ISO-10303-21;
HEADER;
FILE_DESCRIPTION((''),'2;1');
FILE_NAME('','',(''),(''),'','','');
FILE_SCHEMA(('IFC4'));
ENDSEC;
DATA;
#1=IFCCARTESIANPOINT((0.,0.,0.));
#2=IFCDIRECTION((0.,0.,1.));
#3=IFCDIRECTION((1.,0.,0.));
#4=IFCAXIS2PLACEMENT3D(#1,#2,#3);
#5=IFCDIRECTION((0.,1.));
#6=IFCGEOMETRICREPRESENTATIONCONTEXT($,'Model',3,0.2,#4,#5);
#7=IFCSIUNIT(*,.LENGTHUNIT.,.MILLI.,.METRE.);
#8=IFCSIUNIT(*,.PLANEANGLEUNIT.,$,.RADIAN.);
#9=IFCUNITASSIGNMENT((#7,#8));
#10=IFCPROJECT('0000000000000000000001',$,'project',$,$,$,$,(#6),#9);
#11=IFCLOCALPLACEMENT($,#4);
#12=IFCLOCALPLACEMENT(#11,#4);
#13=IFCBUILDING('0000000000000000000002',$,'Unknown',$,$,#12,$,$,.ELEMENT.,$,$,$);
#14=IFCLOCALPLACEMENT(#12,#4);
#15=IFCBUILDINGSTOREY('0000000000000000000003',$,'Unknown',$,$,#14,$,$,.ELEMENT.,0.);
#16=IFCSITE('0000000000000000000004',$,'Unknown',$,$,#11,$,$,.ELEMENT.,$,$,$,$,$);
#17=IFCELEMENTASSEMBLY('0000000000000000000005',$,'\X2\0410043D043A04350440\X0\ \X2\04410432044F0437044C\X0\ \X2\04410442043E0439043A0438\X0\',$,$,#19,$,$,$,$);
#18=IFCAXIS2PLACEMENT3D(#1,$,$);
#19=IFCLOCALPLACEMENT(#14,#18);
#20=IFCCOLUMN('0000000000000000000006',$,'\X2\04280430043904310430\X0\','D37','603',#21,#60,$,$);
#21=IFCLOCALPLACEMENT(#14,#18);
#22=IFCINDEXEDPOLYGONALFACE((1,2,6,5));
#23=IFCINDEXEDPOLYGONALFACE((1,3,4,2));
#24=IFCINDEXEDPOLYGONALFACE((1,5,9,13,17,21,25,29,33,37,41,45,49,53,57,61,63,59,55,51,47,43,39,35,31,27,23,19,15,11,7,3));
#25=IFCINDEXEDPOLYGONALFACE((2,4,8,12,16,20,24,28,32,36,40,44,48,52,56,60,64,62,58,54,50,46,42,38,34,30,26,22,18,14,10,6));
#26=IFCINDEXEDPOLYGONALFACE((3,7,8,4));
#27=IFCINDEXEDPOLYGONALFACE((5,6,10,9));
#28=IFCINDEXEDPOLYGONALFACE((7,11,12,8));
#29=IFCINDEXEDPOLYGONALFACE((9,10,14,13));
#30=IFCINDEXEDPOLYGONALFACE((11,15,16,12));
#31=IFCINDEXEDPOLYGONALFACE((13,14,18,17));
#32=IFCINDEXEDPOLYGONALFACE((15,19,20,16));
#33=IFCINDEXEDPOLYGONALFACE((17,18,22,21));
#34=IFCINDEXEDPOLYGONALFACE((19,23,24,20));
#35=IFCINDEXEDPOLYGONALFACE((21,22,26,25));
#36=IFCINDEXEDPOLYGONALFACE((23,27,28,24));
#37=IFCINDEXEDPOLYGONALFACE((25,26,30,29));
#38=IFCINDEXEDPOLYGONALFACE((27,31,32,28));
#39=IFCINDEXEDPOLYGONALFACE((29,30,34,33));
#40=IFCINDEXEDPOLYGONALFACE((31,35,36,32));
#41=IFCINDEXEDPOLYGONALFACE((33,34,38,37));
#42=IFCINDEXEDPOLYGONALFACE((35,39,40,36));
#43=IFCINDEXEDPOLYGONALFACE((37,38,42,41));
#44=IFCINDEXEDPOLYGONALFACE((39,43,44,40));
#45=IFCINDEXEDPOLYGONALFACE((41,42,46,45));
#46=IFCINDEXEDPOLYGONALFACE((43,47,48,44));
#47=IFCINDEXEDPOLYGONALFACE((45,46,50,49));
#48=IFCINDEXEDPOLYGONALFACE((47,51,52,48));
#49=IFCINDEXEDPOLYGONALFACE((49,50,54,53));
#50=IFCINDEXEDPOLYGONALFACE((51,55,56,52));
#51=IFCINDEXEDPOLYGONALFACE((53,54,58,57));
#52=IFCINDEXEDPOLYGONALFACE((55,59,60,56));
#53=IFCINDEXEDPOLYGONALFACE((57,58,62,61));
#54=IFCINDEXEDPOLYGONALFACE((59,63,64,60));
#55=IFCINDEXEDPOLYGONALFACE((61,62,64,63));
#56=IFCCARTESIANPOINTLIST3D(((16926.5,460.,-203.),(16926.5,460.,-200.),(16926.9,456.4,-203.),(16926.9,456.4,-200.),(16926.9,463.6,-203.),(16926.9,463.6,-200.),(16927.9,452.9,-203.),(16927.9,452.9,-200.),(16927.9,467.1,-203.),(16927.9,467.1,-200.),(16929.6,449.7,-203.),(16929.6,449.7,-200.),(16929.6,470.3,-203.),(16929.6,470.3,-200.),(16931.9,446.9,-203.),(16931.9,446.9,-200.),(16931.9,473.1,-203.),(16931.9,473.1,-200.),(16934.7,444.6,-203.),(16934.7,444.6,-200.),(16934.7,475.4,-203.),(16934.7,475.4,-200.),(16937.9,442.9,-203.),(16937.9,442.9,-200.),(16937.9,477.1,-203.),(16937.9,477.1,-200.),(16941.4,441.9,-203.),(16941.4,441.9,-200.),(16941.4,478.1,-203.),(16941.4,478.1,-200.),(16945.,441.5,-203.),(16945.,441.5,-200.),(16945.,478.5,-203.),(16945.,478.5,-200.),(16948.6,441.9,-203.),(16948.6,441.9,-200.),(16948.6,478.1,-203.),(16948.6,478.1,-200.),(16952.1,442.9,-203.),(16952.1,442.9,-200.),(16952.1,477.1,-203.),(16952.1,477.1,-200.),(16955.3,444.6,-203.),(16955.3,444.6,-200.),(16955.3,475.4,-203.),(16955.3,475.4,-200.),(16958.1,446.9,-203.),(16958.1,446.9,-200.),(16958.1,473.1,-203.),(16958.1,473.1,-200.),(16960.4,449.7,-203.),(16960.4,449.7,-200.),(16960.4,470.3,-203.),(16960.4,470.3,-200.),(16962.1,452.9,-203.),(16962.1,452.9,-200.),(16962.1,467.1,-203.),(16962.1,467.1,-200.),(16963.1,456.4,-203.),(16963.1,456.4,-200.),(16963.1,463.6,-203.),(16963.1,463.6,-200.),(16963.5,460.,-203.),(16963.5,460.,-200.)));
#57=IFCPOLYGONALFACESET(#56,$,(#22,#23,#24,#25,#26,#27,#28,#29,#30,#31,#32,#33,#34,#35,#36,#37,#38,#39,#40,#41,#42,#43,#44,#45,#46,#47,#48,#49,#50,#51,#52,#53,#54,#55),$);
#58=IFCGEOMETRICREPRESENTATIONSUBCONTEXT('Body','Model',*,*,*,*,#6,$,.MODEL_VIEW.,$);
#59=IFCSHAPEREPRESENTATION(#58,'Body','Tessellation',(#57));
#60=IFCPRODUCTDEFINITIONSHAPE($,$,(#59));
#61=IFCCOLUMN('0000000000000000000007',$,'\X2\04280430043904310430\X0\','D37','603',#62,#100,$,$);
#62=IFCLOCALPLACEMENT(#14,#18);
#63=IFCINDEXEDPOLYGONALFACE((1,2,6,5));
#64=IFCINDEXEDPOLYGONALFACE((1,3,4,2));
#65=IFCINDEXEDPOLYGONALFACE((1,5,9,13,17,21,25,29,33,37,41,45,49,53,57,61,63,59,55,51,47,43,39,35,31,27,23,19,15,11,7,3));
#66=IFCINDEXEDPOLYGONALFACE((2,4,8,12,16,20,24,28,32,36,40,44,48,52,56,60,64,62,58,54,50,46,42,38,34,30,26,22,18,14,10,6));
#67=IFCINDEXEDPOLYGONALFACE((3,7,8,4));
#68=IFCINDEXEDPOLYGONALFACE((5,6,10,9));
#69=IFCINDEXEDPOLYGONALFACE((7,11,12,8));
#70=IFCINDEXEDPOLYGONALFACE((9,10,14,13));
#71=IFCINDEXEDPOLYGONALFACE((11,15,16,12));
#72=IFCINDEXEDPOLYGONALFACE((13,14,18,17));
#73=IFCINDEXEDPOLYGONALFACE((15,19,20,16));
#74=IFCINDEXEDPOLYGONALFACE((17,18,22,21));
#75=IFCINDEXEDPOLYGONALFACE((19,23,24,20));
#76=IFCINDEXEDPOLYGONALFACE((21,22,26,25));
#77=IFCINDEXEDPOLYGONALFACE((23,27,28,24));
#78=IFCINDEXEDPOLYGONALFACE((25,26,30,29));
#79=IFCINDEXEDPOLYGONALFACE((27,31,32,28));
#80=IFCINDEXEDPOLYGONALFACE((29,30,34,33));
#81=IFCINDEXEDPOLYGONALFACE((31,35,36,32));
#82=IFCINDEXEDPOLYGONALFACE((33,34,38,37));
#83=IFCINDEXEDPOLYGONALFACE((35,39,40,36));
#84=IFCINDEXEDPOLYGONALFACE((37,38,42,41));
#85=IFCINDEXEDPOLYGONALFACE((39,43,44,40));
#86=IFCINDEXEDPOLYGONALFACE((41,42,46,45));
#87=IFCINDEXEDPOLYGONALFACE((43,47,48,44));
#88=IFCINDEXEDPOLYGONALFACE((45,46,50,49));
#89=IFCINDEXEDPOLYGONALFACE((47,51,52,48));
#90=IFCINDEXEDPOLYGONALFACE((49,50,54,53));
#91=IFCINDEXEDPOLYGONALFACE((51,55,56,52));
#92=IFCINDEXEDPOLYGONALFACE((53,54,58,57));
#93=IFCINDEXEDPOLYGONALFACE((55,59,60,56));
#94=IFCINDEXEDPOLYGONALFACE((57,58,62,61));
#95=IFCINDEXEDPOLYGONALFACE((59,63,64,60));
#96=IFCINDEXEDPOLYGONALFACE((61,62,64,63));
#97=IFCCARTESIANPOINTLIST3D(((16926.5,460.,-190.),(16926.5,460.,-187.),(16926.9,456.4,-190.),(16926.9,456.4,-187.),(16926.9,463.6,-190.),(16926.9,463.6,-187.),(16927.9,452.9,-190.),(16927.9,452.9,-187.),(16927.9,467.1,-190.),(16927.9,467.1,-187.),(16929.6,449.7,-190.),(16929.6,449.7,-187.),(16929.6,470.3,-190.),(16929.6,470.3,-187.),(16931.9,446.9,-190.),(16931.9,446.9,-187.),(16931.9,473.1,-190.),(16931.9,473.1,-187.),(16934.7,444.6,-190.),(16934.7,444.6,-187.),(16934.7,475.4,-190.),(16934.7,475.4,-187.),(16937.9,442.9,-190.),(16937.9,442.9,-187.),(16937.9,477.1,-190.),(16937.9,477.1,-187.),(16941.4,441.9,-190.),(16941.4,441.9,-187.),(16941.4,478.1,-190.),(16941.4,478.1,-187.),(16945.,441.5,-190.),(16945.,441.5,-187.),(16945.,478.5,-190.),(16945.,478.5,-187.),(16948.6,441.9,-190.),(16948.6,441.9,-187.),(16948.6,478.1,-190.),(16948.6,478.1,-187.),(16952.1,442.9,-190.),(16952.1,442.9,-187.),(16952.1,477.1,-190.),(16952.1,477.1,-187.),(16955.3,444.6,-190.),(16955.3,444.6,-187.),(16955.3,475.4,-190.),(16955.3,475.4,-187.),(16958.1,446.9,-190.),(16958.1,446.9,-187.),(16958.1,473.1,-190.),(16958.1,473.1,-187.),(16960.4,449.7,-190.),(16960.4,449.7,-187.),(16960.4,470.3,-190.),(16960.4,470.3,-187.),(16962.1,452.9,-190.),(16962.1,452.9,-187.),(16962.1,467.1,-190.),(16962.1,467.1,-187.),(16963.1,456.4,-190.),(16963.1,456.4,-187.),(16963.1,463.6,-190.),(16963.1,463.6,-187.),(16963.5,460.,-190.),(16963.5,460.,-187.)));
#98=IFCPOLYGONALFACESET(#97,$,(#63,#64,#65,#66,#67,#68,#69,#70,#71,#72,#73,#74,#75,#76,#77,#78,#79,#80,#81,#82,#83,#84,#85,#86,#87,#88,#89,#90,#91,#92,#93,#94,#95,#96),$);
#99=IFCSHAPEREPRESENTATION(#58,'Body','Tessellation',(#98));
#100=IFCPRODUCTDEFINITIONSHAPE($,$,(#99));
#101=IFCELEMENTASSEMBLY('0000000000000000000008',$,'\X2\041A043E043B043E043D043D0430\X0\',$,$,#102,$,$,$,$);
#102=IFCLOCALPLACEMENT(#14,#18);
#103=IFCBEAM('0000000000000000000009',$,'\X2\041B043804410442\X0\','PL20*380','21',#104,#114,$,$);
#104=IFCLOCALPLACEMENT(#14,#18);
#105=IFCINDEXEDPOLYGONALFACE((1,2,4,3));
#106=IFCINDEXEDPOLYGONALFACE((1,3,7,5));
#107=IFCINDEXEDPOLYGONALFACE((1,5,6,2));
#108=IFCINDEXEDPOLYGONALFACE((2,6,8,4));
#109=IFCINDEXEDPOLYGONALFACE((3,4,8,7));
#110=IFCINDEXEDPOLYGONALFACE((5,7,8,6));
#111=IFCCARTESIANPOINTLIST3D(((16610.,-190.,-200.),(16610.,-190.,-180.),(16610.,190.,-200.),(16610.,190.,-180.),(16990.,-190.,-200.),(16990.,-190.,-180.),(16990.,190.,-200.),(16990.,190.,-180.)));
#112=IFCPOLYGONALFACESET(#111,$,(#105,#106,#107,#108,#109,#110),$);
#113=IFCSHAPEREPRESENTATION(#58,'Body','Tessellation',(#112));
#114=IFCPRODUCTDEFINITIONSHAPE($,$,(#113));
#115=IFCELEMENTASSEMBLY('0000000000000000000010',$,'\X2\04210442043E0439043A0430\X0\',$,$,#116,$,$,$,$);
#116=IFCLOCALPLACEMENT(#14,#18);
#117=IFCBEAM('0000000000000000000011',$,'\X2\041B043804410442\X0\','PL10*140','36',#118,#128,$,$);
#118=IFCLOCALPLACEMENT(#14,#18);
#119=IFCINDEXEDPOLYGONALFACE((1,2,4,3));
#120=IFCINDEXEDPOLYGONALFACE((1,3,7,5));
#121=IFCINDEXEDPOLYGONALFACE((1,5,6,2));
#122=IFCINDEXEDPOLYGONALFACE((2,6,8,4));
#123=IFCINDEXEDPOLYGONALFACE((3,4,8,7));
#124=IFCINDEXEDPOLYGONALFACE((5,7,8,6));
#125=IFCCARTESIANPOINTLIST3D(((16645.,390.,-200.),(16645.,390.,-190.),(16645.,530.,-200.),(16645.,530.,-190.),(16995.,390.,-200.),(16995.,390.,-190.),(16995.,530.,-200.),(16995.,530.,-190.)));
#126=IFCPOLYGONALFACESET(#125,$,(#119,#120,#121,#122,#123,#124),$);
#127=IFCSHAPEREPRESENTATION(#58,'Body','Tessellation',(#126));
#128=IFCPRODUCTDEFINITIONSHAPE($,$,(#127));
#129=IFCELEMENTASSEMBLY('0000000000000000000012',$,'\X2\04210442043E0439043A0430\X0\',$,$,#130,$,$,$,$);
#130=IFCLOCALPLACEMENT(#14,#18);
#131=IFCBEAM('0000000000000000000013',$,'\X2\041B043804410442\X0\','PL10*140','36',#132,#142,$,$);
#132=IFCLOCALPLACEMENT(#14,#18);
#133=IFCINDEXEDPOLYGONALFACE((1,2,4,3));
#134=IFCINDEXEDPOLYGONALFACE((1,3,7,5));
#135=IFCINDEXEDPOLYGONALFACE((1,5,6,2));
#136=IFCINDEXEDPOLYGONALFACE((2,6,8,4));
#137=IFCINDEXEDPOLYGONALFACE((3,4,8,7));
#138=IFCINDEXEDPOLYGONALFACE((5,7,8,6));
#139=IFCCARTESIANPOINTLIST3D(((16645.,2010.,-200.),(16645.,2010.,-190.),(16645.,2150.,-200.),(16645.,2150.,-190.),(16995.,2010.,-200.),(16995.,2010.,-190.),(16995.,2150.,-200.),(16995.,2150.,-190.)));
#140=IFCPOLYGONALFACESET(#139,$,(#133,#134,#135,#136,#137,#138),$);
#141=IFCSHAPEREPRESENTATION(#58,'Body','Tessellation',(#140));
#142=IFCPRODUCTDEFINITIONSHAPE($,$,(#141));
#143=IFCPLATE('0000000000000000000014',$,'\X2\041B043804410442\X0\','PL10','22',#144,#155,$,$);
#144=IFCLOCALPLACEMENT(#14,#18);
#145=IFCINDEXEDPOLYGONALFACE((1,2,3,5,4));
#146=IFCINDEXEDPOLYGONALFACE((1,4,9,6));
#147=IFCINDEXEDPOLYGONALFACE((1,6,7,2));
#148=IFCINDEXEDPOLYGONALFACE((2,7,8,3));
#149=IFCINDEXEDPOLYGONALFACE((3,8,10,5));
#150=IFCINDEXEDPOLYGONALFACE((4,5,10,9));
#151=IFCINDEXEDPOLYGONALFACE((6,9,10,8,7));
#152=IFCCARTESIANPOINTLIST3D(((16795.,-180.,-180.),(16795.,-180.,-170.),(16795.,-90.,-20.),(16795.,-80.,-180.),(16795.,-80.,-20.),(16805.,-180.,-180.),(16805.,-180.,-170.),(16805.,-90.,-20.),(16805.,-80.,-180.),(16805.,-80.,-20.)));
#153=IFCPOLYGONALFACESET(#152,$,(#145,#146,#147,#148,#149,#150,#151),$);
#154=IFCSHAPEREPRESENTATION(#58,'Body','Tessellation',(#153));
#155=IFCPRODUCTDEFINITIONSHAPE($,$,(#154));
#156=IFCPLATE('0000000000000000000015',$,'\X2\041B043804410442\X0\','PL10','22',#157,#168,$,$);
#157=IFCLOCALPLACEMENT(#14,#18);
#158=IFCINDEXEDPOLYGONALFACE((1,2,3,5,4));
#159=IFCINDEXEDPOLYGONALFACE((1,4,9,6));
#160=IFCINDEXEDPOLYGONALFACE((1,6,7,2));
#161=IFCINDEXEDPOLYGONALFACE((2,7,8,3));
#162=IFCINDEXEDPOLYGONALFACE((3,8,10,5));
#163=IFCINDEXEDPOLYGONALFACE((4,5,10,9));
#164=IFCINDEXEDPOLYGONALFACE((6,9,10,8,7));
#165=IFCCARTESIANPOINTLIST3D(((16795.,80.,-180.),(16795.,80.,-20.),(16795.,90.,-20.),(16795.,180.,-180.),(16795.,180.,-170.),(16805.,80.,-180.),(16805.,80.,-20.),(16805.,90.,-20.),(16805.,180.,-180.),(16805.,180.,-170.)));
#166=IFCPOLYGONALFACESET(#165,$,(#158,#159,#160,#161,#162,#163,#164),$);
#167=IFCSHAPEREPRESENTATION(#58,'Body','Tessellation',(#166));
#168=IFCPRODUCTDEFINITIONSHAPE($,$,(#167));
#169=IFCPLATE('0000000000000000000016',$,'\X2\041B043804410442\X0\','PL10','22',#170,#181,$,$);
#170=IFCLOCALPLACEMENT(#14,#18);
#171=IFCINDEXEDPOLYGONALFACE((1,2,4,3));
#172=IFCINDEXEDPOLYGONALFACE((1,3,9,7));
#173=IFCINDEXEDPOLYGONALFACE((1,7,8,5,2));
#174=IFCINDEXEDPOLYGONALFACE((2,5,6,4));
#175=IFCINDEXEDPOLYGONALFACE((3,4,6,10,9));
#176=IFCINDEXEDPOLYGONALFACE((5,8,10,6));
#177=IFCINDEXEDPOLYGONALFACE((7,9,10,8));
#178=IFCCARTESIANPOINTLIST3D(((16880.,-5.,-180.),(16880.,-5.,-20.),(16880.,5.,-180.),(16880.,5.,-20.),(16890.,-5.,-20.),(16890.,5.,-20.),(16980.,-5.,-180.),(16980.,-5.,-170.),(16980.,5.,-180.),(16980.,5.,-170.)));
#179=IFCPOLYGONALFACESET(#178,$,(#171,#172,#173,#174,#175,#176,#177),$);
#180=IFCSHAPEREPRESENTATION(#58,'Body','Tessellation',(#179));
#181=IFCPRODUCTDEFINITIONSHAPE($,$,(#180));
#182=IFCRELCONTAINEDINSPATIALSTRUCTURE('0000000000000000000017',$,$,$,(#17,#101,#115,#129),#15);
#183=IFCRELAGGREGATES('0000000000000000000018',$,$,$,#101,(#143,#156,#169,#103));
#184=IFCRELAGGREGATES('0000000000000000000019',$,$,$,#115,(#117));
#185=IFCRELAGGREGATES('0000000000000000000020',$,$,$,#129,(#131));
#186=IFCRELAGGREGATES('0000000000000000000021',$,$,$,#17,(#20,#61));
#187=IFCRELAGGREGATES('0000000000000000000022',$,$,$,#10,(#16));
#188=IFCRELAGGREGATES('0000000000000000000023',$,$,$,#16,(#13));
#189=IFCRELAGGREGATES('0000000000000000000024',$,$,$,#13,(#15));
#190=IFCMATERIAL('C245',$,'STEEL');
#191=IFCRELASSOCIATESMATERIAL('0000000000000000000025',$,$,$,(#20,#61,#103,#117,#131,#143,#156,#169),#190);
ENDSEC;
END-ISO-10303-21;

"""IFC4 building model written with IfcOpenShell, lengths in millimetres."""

from ifc_helpers import new_model, si_unit, direction, frame, origin_with_axes, place, context, subcontext, project, spatial, line, indexed_curve, outline, extrude, material, element, aggregate, save


model = new_model("IFC4")

# Units and contexts
model_context = context("Model", 3, precision=0.2, world=origin_with_axes(), true_north=direction((0.0, 1.0)))
body_context = subcontext(model_context, "Body", "Model", "MODEL_VIEW")
ifc_project = project(units=[si_unit("LENGTHUNIT", "METRE", prefix="MILLI"), si_unit("PLANEANGLEUNIT", "RADIAN")], contexts=[model_context])

# Site, building, storey
site_placement = place(None, origin_with_axes())
site = spatial("IfcSite", under=ifc_project, at=site_placement, Name="Unknown", CompositionType="ELEMENT")
building_placement = place(site_placement, origin_with_axes())
building = spatial("IfcBuilding", under=site, at=building_placement, Name="Unknown", CompositionType="ELEMENT")
storey_placement = place(building_placement, origin_with_axes())
storey = spatial("IfcBuildingStorey", under=building, at=storey_placement, Name="Unknown", CompositionType="ELEMENT", Elevation=0.0)

# Element assembly, columns
ifc_material_1 = material(Name="C245", Category="STEEL")
assembly_1_placement = place(storey_placement, frame((16945.0, 460.0, -160.0), z_axis=(0.0, -1.0, 0.0), x_axis=(0.0, 0.0, -1.0)))
assembly_1 = element("IfcElementAssembly", 1, at=assembly_1_placement, inside=storey, Name="Анкер связь стойки")
column_1_placement = place(assembly_1_placement, frame((40.0, 0.0, 0.0), z_axis=(0.0, -1.0, 0.0), x_axis=(1.0, 0.0, 0.0)))
column_1 = element("IfcColumn", 2, at=column_1_placement, material=ifc_material_1, Name="Шайба", Description="D37", ObjectType="603", context=body_context, shape_type="SolidModel", body=[
    extrude(outline(indexed_curve([(18.5, 0.0), (18.1, 3.6), (17.1, 7.1), (15.4, 10.3), (13.1, 13.1), (10.3, 15.4), (7.1, 17.1), (3.6, 18.1), (0.0, 18.5), (-3.6, 18.1), (-7.1, 17.1), (-10.3, 15.4), (-13.1, 13.1), (-15.4, 10.3), (-17.1, 7.1), (-18.1, 3.6), (-18.5, 0.0), (-18.1, -3.6), (-17.1, -7.1), (-15.4, -10.3), (-13.1, -13.1), (-10.3, -15.4), (-7.1, -17.1), (-3.6, -18.1), (0.0, -18.5), (3.6, -18.1), (7.1, -17.1), (10.3, -15.4), (13.1, -13.1), (15.4, -10.3), (17.1, -7.1), (18.1, -3.6)], segments=[line(1, 2, 3, 4, 5, 6, 7, 8, 9, 10, 11, 12, 13, 14, 15, 16, 17, 18, 19, 20, 21, 22, 23, 24, 25, 26, 27, 28, 29, 30, 31, 32, 1)])), frame((0.0, 0.0, 0.0), z_axis=(-1.0, 0.0, 0.0), x_axis=(0.0, 0.0, 1.0)), (0.0, 0.0, -1.0), 3.0),
])
column_2_placement = place(assembly_1_placement, frame((27.0, 0.0, 0.0), z_axis=(0.0, 0.0, 1.0), x_axis=(1.0, 0.0, 0.0)))
column_2 = element("IfcColumn", 3, at=column_2_placement, material=ifc_material_1, Name="Шайба", Description="D37", ObjectType="603", context=body_context, shape_type="SolidModel", body=[
    extrude(outline(indexed_curve([(18.5, 0.0), (18.1, 3.6), (17.1, 7.1), (15.4, 10.3), (13.1, 13.1), (10.3, 15.4), (7.1, 17.1), (3.6, 18.1), (0.0, 18.5), (-3.6, 18.1), (-7.1, 17.1), (-10.3, 15.4), (-13.1, 13.1), (-15.4, 10.3), (-17.1, 7.1), (-18.1, 3.6), (-18.5, 0.0), (-18.1, -3.6), (-17.1, -7.1), (-15.4, -10.3), (-13.1, -13.1), (-10.3, -15.4), (-7.1, -17.1), (-3.6, -18.1), (0.0, -18.5), (3.6, -18.1), (7.1, -17.1), (10.3, -15.4), (13.1, -13.1), (15.4, -10.3), (17.1, -7.1), (18.1, -3.6)], segments=[line(1, 2, 3, 4, 5, 6, 7, 8, 9, 10, 11, 12, 13, 14, 15, 16, 17, 18, 19, 20, 21, 22, 23, 24, 25, 26, 27, 28, 29, 30, 31, 32, 1)])), frame((0.0, 0.0, 0.0), z_axis=(-1.0, 0.0, 0.0), x_axis=(0.0, 0.0, 1.0)), (0.0, 0.0, -1.0), 3.0),
])

# Element assemblies, beams
assembly_2_placement = place(storey_placement, frame((16800.0, 0.0, -40.0), z_axis=(-1.0, 0.0, 0.0), x_axis=(0.0, 0.0, 1.0)))
assembly_2 = element("IfcElementAssembly", 4, at=assembly_2_placement, inside=storey, Name="Колонна")
beam_1_placement = place(assembly_2_placement, frame((-150.0, -190.0, 0.0), z_axis=(1.0, 0.0, 0.0), x_axis=(0.0, 1.0, 0.0)))
beam_1 = element("IfcBeam", 5, at=beam_1_placement, material=ifc_material_1, Name="Лист", Description="PL20*380", ObjectType="21", context=body_context, shape_type="SolidModel", body=[
    extrude(outline(indexed_curve([(-10.0, -190.0), (10.0, -190.0), (10.0, 190.0), (-10.0, 190.0)], segments=[line(1, 2, 3, 4, 1)])), frame((0.0, 0.0, 0.0), z_axis=(-1.0, 0.0, 0.0), x_axis=(0.0, 0.0, 1.0)), (0.0, 0.0, -1.0), 380.0),
])
assembly_3_placement = place(storey_placement, frame((16820.0, 460.0, 0.0), z_axis=(0.0, -1.0, 0.0), x_axis=(0.0, 0.0, 1.0)))
assembly_3 = element("IfcElementAssembly", 6, at=assembly_3_placement, inside=storey, Name="Стойка")
beam_2_placement = place(assembly_3_placement, frame((-195.0, -175.0, 0.0), z_axis=(1.0, 0.0, 0.0), x_axis=(0.0, 1.0, 0.0)))
beam_2 = element("IfcBeam", 7, at=beam_2_placement, material=ifc_material_1, Name="Лист", Description="PL10*140", ObjectType="36", context=body_context, shape_type="SolidModel", body=[
    extrude(outline(indexed_curve([(-5.0, -70.0), (5.0, -70.0), (5.0, 70.0), (-5.0, 70.0)], segments=[line(1, 2, 3, 4, 1)])), frame((0.0, 0.0, 0.0), z_axis=(-1.0, 0.0, 0.0), x_axis=(0.0, 0.0, 1.0)), (0.0, 0.0, -1.0), 350.0),
])
assembly_4_placement = place(storey_placement, frame((16820.0, 2080.0, 0.0), z_axis=(0.0, -1.0, 0.0), x_axis=(0.0, 0.0, 1.0)))
assembly_4 = element("IfcElementAssembly", 8, at=assembly_4_placement, inside=storey, Name="Стойка")
beam_3_placement = place(assembly_4_placement, frame((-195.0, -175.0, 0.0), z_axis=(1.0, 0.0, 0.0), x_axis=(0.0, 1.0, 0.0)))
beam_3 = element("IfcBeam", 9, at=beam_3_placement, material=ifc_material_1, Name="Лист", Description="PL10*140", ObjectType="36", context=body_context, shape_type="SolidModel", body=[
    extrude(outline(indexed_curve([(-5.0, -70.0), (5.0, -70.0), (5.0, 70.0), (-5.0, 70.0)], segments=[line(1, 2, 3, 4, 1)])), frame((0.0, 0.0, 0.0), z_axis=(-1.0, 0.0, 0.0), x_axis=(0.0, 0.0, 1.0)), (0.0, 0.0, -1.0), 350.0),
])

# Plates
plate_1_placement = place(assembly_2_placement, frame((-140.0, -180.0, 0.0), z_axis=(0.0, 0.0, -1.0), x_axis=(0.0, 1.0, 0.0)))
plate_1 = element("IfcPlate", 10, at=plate_1_placement, material=ifc_material_1, Name="Лист", Description="PL10", ObjectType="22", context=body_context, shape_type="SolidModel", body=[
    extrude(outline(indexed_curve([(0.0, 0.0), (100.0, 0.0), (100.0, 160.0), (90.0, 160.0), (0.0, 10.0)], segments=[line(1, 2, 3, 4, 5, 1)])), frame((0.0, 0.0, 5.0), z_axis=(0.0, 0.0, 1.0), x_axis=(1.0, 0.0, 0.0)), (0.0, 0.0, -1.0), 10.0),
])
plate_2_placement = place(assembly_2_placement, frame((-140.0, 180.0, 0.0), z_axis=(0.0, 0.0, 1.0), x_axis=(0.0, -1.0, 0.0)))
plate_2 = element("IfcPlate", 11, at=plate_2_placement, material=ifc_material_1, Name="Лист", Description="PL10", ObjectType="22", context=body_context, shape_type="SolidModel", body=[
    extrude(outline(indexed_curve([(0.0, 0.0), (100.0, 0.0), (100.0, 160.0), (90.0, 160.0), (0.0, 10.0)], segments=[line(1, 2, 3, 4, 5, 1)])), frame((0.0, 0.0, 5.0), z_axis=(0.0, 0.0, 1.0), x_axis=(1.0, 0.0, 0.0)), (0.0, 0.0, -1.0), 10.0),
])
plate_3_placement = place(assembly_2_placement, frame((-140.0, 0.0, -180.0), z_axis=(0.0, 1.0, 0.0), x_axis=(0.0, 0.0, 1.0)))
plate_3 = element("IfcPlate", 12, at=plate_3_placement, material=ifc_material_1, Name="Лист", Description="PL10", ObjectType="22", context=body_context, shape_type="SolidModel", body=[
    extrude(outline(indexed_curve([(0.0, 0.0), (100.0, 0.0), (100.0, 160.0), (90.0, 160.0), (0.0, 10.0)], segments=[line(1, 2, 3, 4, 5, 1)])), frame((0.0, 0.0, 5.0), z_axis=(0.0, 0.0, 1.0), x_axis=(1.0, 0.0, 0.0)), (0.0, 0.0, -1.0), 10.0),
])

aggregate(assembly_2, [plate_1, plate_2, plate_3, beam_1])
aggregate(assembly_3, [beam_2])
aggregate(assembly_4, [beam_3])
aggregate(assembly_1, [column_1, column_2])

save(model, "model.ifc")
